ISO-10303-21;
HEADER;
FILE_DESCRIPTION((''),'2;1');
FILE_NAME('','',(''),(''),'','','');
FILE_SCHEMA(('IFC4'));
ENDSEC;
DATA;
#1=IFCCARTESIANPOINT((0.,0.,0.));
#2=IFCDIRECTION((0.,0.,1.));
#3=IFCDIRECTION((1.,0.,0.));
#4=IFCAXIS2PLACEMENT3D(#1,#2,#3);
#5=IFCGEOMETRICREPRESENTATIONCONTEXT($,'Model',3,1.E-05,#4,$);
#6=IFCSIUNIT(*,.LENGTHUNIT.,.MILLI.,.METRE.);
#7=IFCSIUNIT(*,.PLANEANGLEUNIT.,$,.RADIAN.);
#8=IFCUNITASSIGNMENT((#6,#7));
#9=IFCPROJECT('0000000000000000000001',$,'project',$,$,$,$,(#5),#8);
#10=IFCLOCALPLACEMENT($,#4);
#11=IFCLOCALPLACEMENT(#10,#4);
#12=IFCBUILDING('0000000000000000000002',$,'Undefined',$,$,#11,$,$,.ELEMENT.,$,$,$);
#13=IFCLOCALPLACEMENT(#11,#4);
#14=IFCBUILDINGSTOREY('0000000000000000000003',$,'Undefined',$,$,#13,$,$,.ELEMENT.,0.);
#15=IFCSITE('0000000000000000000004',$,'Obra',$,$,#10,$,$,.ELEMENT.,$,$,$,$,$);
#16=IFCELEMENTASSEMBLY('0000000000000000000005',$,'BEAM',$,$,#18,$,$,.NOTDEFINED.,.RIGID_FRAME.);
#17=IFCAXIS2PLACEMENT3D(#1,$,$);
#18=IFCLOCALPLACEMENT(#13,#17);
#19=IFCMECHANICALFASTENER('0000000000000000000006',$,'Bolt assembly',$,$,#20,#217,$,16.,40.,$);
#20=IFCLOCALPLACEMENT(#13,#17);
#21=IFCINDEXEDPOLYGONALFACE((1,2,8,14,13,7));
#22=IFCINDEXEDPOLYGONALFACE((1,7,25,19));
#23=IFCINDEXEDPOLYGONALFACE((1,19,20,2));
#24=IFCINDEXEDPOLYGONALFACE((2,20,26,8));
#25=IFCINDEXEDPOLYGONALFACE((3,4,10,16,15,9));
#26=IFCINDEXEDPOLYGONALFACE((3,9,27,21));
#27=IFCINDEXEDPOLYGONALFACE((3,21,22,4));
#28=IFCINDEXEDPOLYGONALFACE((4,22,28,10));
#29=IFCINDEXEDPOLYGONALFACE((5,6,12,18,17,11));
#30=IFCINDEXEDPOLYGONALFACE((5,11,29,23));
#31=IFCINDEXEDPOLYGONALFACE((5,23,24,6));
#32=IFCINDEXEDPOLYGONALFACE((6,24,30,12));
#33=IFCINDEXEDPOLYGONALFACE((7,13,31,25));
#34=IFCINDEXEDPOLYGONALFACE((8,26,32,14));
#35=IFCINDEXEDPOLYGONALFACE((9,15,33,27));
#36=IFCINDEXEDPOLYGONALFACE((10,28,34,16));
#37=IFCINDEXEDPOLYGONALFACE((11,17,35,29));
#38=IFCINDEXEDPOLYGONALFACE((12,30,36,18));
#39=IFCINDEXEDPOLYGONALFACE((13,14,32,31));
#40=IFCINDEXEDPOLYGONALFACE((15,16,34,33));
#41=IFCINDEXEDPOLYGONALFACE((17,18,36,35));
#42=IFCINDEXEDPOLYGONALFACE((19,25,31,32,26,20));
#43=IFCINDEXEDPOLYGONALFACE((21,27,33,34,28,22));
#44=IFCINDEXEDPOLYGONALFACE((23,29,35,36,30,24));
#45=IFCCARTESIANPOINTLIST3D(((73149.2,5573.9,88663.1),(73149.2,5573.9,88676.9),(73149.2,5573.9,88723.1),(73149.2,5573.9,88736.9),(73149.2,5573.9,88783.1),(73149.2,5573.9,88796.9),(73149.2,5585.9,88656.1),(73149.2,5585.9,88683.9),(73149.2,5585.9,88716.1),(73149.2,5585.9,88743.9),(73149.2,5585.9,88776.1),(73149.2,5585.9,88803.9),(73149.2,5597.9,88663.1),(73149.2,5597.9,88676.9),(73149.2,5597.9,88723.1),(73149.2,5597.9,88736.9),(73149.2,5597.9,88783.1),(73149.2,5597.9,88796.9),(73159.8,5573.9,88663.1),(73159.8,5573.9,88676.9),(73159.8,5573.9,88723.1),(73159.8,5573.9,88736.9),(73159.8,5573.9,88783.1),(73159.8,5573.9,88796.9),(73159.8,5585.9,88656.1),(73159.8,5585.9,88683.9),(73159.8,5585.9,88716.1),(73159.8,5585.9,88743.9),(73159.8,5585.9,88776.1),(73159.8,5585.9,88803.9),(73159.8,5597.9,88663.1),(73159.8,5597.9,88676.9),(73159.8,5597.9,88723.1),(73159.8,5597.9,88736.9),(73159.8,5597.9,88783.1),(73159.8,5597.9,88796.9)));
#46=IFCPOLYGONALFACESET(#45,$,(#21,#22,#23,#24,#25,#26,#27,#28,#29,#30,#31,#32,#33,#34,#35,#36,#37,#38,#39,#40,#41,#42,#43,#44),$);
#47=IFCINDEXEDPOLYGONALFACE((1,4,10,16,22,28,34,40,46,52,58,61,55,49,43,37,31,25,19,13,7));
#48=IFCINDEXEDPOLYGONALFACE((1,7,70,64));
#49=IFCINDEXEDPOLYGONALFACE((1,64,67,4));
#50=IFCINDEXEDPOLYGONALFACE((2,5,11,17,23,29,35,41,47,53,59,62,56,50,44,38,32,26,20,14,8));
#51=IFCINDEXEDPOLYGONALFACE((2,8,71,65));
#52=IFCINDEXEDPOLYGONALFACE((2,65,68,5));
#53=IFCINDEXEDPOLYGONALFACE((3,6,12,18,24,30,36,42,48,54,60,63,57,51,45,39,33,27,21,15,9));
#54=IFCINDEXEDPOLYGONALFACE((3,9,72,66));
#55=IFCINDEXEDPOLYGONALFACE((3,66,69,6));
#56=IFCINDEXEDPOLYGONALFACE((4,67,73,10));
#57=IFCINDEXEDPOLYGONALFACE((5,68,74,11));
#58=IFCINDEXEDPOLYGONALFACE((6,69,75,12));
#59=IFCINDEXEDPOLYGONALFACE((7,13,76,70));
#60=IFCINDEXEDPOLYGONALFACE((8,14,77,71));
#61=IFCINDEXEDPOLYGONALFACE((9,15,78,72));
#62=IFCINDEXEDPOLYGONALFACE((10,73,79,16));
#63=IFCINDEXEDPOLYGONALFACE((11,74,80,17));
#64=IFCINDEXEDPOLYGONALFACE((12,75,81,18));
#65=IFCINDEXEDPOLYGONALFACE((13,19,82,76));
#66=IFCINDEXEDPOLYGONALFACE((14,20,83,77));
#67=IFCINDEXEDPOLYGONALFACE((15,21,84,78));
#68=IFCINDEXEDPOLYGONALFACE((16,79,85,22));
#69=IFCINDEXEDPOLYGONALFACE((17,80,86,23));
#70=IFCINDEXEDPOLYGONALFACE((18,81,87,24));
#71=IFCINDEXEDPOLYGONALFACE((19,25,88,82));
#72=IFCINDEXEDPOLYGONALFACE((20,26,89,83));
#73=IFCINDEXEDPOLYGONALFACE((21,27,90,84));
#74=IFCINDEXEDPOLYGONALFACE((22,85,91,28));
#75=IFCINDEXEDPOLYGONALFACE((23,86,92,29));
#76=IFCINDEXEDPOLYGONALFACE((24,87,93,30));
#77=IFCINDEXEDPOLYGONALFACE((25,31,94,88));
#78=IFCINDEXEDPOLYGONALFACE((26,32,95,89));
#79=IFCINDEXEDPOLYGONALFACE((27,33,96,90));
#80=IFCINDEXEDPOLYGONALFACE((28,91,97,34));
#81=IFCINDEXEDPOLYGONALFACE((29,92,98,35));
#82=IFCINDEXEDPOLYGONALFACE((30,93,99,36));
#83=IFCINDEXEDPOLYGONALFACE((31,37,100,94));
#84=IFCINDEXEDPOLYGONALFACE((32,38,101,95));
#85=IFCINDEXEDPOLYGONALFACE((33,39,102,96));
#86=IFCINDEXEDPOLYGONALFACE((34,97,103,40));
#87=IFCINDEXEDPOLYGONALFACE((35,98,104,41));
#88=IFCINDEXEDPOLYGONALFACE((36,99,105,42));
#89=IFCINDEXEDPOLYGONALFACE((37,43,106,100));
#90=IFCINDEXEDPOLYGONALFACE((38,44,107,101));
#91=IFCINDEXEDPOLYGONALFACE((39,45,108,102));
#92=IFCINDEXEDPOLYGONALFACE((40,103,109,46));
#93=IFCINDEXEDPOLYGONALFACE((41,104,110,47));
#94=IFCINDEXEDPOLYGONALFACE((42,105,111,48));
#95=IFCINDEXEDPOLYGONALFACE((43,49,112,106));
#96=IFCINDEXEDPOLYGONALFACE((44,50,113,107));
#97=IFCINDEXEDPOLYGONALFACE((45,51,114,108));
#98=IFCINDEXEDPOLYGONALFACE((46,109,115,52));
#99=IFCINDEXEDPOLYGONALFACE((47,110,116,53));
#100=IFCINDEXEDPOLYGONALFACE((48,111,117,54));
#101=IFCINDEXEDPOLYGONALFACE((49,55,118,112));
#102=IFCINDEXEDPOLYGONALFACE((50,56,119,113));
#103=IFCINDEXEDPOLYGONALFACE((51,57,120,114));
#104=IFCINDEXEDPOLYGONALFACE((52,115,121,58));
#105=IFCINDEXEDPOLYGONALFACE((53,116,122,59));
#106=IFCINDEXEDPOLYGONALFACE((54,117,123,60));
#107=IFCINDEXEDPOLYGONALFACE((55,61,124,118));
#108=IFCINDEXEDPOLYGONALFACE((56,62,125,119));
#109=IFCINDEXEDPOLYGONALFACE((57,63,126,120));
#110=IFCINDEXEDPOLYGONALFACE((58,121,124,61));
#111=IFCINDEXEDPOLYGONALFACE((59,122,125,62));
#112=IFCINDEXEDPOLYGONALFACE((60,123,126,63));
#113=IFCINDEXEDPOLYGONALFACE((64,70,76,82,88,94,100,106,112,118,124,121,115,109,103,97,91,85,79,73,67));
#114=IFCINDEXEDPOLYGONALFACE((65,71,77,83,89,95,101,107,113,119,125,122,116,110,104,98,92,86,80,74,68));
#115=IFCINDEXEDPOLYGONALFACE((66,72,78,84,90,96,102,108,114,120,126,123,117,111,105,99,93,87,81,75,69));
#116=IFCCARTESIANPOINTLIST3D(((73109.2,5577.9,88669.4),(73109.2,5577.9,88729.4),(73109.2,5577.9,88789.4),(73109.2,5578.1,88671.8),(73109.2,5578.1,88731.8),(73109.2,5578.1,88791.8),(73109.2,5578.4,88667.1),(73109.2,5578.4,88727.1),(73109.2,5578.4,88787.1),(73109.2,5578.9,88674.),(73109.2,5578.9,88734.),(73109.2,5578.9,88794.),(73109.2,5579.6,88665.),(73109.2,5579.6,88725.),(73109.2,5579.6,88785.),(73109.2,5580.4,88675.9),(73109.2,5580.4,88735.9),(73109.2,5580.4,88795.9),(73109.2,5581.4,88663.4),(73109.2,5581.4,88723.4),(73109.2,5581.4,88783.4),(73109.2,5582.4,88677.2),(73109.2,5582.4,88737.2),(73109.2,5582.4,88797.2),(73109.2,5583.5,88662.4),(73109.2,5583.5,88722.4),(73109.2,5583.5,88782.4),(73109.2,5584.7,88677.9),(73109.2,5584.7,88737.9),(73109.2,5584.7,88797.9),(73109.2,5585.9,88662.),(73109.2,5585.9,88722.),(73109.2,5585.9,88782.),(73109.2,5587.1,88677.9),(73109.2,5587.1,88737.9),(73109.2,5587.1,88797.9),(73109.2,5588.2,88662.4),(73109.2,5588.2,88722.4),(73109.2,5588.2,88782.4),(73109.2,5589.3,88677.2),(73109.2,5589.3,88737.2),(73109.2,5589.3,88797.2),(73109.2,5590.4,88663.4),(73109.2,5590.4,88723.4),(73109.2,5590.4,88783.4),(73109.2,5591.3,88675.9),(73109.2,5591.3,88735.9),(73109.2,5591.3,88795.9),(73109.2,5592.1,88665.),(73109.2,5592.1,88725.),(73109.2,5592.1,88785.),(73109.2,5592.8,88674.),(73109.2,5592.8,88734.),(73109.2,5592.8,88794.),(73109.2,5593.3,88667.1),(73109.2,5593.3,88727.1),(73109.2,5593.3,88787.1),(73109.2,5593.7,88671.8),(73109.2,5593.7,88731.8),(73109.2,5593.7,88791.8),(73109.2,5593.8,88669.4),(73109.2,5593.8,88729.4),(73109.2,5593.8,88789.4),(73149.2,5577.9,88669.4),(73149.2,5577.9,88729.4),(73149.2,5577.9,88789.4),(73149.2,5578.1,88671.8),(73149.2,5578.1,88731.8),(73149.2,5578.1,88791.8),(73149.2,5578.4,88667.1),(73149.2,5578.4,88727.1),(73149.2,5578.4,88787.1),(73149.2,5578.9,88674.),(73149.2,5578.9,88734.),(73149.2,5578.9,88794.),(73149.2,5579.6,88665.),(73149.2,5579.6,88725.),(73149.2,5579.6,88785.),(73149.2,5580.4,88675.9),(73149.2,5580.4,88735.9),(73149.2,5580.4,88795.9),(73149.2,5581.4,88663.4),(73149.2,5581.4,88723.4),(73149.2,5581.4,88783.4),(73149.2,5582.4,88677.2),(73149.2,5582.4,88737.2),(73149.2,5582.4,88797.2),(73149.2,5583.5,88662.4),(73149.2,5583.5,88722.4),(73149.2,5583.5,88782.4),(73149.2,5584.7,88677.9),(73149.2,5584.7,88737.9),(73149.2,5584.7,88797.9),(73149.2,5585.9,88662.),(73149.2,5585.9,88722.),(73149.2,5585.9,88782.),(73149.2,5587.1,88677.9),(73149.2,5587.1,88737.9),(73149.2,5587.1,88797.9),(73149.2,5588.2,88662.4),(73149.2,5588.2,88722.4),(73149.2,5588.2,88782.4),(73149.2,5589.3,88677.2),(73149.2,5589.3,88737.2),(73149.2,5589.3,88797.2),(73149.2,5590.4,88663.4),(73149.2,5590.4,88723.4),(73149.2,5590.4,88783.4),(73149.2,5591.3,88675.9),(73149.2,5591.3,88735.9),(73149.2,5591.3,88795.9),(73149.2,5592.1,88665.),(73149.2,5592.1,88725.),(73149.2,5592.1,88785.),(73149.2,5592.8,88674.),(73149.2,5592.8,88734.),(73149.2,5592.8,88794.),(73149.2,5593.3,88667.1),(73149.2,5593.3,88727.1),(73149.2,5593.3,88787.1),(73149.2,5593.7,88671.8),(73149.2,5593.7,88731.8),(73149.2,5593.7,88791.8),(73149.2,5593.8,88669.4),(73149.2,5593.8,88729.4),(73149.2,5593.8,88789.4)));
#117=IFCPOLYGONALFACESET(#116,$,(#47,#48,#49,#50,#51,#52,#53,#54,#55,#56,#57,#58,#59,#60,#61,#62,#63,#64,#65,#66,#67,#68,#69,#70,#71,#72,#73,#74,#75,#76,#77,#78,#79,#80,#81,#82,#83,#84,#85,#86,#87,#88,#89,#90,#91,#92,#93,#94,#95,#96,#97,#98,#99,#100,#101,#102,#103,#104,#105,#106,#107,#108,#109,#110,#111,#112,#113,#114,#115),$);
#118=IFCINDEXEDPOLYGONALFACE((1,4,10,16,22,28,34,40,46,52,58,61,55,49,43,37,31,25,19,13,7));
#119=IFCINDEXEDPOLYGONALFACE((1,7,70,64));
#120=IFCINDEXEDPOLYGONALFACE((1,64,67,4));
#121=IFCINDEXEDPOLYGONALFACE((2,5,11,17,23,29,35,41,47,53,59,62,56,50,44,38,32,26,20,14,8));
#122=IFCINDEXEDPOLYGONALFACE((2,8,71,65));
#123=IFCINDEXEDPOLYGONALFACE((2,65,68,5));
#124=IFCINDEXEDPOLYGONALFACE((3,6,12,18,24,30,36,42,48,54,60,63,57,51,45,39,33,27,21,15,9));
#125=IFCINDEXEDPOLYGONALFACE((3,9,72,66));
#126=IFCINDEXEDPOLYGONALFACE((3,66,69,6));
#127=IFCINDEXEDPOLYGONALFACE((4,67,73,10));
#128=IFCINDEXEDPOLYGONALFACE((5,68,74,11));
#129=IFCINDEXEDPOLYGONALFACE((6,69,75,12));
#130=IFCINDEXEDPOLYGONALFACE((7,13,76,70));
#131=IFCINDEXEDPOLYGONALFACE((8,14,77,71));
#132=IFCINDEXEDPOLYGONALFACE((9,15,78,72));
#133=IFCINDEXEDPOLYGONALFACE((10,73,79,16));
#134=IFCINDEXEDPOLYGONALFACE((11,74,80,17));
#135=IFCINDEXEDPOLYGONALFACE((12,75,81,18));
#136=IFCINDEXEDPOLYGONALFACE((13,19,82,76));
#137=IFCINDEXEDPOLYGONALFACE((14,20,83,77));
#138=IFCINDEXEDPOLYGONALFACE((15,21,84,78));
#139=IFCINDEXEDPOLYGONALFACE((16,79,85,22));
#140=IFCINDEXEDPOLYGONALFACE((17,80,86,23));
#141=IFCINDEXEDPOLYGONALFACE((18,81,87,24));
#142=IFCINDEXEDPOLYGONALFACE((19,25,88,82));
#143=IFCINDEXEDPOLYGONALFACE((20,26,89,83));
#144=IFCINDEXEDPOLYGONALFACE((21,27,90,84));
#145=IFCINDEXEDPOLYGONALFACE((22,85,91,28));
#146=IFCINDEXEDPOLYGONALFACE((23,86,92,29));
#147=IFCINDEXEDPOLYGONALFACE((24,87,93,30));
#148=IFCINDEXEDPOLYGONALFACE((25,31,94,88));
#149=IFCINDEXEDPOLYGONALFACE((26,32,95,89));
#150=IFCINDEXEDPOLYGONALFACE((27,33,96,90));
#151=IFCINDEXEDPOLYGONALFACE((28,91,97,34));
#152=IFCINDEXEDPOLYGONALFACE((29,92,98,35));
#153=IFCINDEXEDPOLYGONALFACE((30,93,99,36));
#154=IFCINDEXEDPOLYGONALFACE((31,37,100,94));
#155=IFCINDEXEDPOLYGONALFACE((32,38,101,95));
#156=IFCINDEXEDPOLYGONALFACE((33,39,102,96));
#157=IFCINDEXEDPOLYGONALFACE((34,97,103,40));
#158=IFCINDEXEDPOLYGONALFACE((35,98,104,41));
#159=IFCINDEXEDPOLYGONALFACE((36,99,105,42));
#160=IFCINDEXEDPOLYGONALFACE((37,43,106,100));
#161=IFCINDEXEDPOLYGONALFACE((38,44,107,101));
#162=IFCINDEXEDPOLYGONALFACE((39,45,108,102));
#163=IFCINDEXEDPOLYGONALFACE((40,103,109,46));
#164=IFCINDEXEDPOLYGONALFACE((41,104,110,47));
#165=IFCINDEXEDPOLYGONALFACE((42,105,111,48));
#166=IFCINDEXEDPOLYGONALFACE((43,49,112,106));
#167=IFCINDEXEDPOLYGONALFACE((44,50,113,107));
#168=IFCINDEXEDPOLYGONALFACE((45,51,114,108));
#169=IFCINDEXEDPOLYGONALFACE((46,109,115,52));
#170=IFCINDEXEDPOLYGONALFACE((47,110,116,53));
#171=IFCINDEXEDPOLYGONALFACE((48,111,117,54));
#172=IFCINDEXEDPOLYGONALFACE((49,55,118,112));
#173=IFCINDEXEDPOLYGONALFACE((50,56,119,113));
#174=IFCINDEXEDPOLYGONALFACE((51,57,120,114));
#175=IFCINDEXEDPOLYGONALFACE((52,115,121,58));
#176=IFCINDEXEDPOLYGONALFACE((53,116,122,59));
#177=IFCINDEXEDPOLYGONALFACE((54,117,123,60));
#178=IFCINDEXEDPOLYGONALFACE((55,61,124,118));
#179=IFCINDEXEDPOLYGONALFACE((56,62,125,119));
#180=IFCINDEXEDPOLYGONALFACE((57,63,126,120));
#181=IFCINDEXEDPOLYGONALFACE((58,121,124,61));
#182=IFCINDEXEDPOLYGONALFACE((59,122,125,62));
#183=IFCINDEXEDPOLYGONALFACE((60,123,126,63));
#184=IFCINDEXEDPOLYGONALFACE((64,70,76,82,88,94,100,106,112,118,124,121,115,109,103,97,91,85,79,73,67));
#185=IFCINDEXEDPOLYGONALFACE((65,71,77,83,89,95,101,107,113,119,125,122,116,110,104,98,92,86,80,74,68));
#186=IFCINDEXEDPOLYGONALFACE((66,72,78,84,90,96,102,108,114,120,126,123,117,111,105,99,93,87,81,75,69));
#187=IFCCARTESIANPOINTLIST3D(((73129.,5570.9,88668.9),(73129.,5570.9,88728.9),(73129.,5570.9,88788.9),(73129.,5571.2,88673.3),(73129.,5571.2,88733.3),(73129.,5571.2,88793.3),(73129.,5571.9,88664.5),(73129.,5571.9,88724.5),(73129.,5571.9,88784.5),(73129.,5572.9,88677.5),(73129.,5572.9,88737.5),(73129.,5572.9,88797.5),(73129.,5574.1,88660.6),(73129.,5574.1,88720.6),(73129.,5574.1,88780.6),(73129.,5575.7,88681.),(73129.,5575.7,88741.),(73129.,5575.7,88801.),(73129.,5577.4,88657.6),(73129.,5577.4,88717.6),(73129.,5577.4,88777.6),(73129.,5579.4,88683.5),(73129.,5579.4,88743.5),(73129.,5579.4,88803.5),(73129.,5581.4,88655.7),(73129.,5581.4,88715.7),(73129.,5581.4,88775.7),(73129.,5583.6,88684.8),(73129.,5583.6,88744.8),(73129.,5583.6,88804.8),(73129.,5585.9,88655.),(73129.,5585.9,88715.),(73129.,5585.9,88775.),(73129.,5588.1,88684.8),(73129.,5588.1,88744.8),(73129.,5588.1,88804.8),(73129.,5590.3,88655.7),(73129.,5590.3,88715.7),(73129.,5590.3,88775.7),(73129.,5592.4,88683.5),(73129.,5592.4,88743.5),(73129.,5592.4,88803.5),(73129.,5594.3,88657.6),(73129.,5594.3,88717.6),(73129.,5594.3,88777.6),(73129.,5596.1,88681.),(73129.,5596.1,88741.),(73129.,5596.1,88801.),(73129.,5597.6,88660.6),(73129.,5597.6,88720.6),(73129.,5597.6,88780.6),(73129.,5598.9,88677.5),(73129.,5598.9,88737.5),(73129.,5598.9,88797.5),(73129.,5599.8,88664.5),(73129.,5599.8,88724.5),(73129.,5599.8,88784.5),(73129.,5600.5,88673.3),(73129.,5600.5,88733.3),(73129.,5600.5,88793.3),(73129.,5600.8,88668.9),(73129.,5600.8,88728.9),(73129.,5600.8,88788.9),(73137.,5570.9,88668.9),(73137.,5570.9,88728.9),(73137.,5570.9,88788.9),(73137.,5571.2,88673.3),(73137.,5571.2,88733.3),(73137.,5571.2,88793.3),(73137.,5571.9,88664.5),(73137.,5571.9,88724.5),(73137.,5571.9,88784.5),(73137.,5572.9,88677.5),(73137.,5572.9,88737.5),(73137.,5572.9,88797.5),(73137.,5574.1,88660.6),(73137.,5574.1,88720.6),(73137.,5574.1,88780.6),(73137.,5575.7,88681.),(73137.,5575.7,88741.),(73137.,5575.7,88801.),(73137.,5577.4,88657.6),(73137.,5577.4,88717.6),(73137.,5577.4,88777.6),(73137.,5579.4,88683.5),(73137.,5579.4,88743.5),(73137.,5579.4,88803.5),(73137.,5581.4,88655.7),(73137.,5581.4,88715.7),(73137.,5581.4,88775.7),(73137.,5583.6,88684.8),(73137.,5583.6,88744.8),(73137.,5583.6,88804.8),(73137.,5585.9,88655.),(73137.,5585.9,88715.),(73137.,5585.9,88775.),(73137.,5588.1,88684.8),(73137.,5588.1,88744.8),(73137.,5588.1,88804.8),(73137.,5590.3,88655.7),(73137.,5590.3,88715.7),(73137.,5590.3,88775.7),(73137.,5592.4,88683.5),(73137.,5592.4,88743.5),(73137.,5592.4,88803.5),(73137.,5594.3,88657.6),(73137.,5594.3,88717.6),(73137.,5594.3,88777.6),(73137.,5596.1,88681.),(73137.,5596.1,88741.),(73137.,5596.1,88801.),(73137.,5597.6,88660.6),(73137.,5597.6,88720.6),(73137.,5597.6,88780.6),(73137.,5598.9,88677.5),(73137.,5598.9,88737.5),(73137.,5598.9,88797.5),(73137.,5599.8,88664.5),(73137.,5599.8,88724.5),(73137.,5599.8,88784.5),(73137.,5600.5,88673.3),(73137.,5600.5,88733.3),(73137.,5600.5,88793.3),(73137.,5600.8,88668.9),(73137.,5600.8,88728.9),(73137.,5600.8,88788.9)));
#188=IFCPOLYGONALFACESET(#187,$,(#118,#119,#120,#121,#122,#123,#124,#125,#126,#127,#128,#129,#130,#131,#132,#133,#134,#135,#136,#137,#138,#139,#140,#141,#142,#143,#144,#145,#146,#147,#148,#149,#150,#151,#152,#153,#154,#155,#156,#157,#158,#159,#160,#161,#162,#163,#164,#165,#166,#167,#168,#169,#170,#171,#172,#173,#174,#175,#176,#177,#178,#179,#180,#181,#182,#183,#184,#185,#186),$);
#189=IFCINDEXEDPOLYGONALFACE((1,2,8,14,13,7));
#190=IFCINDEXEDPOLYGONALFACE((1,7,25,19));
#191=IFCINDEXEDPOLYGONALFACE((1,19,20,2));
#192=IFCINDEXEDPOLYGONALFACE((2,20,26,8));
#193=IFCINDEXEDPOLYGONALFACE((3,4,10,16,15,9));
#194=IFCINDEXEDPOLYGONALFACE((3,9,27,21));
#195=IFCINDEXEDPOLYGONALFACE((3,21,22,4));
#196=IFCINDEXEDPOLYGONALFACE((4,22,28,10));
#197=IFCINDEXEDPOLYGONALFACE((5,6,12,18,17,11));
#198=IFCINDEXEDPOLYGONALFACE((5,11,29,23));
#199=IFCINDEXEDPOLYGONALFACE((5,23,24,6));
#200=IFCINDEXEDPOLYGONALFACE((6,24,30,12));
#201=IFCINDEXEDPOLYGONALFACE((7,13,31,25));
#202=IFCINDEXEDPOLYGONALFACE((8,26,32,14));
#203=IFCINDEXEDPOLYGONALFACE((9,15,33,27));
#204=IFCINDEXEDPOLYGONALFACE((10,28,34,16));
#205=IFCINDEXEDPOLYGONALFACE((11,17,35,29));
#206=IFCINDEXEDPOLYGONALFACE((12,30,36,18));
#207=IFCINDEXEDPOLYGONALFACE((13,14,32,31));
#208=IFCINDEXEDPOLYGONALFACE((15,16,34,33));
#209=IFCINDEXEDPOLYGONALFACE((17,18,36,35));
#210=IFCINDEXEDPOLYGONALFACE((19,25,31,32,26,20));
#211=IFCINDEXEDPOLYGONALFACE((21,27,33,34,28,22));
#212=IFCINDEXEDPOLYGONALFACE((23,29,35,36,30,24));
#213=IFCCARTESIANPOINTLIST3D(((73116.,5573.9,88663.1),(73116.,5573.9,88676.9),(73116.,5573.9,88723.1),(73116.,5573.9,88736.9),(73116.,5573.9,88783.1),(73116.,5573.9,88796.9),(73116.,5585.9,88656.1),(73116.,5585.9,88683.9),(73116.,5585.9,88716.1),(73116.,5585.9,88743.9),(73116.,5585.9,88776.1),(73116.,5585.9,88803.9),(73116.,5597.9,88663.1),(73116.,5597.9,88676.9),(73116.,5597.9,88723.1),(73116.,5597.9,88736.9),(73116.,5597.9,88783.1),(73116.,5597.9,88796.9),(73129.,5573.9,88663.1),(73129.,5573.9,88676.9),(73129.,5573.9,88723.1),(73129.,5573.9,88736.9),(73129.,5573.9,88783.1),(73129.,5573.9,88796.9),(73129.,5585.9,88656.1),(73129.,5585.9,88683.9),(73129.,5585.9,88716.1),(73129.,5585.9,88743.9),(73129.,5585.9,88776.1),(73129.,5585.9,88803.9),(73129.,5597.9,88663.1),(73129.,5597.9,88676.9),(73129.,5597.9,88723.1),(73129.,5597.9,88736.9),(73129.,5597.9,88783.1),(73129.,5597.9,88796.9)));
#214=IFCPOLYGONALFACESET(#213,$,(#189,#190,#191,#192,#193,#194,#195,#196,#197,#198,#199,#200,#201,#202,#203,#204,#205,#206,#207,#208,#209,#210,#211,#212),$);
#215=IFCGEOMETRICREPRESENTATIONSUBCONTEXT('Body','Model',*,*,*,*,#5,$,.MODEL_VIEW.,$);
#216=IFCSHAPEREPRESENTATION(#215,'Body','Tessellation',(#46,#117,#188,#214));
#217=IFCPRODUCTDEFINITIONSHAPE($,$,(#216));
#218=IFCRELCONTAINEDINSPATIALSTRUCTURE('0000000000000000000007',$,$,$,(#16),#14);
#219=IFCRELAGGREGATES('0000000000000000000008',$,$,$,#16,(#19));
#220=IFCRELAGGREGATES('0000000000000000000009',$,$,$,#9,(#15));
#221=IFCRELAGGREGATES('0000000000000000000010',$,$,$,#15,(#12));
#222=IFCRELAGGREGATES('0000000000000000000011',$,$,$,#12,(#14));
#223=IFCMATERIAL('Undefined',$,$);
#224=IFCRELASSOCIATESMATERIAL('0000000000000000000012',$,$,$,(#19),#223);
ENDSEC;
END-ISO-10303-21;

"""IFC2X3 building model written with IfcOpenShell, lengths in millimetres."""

from ifc_helpers import new_model, si_unit, frame, origin_with_axes, origin_2d_with_axis, place, context, subcontext, project, spatial, polyline, circle, outline, extrude, source, transform, mapped, material, element, aggregate, save


model = new_model("IFC2X3")

# Units and contexts
model_context = context("Model", 3, precision=1e-05, world=origin_with_axes())
body_context = subcontext(model_context, "Body", "Model", "MODEL_VIEW")
ifc_project = project(units=[si_unit("LENGTHUNIT", "METRE", prefix="MILLI"), si_unit("PLANEANGLEUNIT", "RADIAN")], contexts=[model_context])

# Site, building, storey
site_placement = place(None, origin_with_axes())
site = spatial("IfcSite", under=ifc_project, at=site_placement, Name="Obra", CompositionType="ELEMENT")
building_placement = place(site_placement, origin_with_axes())
building = spatial("IfcBuilding", under=site, at=building_placement, Name="Undefined", CompositionType="ELEMENT")
storey_placement = place(building_placement, origin_with_axes())
storey = spatial("IfcBuildingStorey", under=building, at=storey_placement, Name="Undefined", CompositionType="ELEMENT", Elevation=0.0)

# Shared definitions
ifc_material_1 = material(Name="Undefined")

# Element assembly, mechanical fastener
assembly_1_placement = place(storey_placement, origin_with_axes())
assembly_1 = element("IfcElementAssembly", 1, at=assembly_1_placement, inside=storey, Name="BEAM", AssemblyPlace="NOTDEFINED", PredefinedType="RIGID_FRAME")
shared_shape_1 = source(origin_with_axes(), body_context, "Body", "SweptSolid", [
    extrude(outline(polyline([(13.9, 0.0), (6.9, 12.0), (-6.9, 12.0), (-13.9, 0.0), (-6.9, -12.0), (6.9, -12.0), (13.9, 0.0)])), frame((0.0, -19.7, 0.0), z_axis=(0.0, 1.0, 0.0), x_axis=(1.0, 0.0, 0.0)), (0.0, 0.0, 1.0), 10.6),
    extrude(circle(Radius=8.0, at=origin_2d_with_axis()), frame((0.0, -9.1, 0.0), z_axis=(0.0, 1.0, 0.0), x_axis=(1.0, 0.0, 0.0)), (0.0, 0.0, 1.0), 40.0),
    extrude(circle(Radius=15.0, at=origin_2d_with_axis()), frame((0.0, 3.1, 0.0), z_axis=(0.0, 1.0, 0.0), x_axis=(1.0, 0.0, 0.0)), (0.0, 0.0, 1.0), 8.0),
    extrude(outline(polyline([(13.9, 0.0), (6.9, 12.0), (-6.9, 12.0), (-13.9, 0.0), (-6.9, -12.0), (6.9, -12.0), (13.9, 0.0)])), frame((0.0, 11.1, 0.0), z_axis=(0.0, 1.0, 0.0), x_axis=(1.0, 0.0, 0.0)), (0.0, 0.0, 1.0), 13.0),
])
mechanical_fastener_1_placement = place(assembly_1_placement, frame((73140.1, 5535.9, 88850.0), z_axis=(0.0, 1.0, 0.0), x_axis=(0.0, 0.0, -1.0)))
mechanical_fastener_1 = element("IfcMechanicalFastener", 2, at=mechanical_fastener_1_placement, material=ifc_material_1, Name="Bolt assembly", NominalDiameter=16.0, NominalLength=40.0, context=body_context, shape_type="MappedRepresentation", body=[
    mapped(shared_shape_1, transform((60.0, 0.0, 50.0))),
    mapped(shared_shape_1, transform((120.0, 0.0, 50.0))),
    mapped(shared_shape_1, transform((180.0, 0.0, 50.0))),
])
aggregate(assembly_1, [mechanical_fastener_1])

save(model, "model.ifc")
